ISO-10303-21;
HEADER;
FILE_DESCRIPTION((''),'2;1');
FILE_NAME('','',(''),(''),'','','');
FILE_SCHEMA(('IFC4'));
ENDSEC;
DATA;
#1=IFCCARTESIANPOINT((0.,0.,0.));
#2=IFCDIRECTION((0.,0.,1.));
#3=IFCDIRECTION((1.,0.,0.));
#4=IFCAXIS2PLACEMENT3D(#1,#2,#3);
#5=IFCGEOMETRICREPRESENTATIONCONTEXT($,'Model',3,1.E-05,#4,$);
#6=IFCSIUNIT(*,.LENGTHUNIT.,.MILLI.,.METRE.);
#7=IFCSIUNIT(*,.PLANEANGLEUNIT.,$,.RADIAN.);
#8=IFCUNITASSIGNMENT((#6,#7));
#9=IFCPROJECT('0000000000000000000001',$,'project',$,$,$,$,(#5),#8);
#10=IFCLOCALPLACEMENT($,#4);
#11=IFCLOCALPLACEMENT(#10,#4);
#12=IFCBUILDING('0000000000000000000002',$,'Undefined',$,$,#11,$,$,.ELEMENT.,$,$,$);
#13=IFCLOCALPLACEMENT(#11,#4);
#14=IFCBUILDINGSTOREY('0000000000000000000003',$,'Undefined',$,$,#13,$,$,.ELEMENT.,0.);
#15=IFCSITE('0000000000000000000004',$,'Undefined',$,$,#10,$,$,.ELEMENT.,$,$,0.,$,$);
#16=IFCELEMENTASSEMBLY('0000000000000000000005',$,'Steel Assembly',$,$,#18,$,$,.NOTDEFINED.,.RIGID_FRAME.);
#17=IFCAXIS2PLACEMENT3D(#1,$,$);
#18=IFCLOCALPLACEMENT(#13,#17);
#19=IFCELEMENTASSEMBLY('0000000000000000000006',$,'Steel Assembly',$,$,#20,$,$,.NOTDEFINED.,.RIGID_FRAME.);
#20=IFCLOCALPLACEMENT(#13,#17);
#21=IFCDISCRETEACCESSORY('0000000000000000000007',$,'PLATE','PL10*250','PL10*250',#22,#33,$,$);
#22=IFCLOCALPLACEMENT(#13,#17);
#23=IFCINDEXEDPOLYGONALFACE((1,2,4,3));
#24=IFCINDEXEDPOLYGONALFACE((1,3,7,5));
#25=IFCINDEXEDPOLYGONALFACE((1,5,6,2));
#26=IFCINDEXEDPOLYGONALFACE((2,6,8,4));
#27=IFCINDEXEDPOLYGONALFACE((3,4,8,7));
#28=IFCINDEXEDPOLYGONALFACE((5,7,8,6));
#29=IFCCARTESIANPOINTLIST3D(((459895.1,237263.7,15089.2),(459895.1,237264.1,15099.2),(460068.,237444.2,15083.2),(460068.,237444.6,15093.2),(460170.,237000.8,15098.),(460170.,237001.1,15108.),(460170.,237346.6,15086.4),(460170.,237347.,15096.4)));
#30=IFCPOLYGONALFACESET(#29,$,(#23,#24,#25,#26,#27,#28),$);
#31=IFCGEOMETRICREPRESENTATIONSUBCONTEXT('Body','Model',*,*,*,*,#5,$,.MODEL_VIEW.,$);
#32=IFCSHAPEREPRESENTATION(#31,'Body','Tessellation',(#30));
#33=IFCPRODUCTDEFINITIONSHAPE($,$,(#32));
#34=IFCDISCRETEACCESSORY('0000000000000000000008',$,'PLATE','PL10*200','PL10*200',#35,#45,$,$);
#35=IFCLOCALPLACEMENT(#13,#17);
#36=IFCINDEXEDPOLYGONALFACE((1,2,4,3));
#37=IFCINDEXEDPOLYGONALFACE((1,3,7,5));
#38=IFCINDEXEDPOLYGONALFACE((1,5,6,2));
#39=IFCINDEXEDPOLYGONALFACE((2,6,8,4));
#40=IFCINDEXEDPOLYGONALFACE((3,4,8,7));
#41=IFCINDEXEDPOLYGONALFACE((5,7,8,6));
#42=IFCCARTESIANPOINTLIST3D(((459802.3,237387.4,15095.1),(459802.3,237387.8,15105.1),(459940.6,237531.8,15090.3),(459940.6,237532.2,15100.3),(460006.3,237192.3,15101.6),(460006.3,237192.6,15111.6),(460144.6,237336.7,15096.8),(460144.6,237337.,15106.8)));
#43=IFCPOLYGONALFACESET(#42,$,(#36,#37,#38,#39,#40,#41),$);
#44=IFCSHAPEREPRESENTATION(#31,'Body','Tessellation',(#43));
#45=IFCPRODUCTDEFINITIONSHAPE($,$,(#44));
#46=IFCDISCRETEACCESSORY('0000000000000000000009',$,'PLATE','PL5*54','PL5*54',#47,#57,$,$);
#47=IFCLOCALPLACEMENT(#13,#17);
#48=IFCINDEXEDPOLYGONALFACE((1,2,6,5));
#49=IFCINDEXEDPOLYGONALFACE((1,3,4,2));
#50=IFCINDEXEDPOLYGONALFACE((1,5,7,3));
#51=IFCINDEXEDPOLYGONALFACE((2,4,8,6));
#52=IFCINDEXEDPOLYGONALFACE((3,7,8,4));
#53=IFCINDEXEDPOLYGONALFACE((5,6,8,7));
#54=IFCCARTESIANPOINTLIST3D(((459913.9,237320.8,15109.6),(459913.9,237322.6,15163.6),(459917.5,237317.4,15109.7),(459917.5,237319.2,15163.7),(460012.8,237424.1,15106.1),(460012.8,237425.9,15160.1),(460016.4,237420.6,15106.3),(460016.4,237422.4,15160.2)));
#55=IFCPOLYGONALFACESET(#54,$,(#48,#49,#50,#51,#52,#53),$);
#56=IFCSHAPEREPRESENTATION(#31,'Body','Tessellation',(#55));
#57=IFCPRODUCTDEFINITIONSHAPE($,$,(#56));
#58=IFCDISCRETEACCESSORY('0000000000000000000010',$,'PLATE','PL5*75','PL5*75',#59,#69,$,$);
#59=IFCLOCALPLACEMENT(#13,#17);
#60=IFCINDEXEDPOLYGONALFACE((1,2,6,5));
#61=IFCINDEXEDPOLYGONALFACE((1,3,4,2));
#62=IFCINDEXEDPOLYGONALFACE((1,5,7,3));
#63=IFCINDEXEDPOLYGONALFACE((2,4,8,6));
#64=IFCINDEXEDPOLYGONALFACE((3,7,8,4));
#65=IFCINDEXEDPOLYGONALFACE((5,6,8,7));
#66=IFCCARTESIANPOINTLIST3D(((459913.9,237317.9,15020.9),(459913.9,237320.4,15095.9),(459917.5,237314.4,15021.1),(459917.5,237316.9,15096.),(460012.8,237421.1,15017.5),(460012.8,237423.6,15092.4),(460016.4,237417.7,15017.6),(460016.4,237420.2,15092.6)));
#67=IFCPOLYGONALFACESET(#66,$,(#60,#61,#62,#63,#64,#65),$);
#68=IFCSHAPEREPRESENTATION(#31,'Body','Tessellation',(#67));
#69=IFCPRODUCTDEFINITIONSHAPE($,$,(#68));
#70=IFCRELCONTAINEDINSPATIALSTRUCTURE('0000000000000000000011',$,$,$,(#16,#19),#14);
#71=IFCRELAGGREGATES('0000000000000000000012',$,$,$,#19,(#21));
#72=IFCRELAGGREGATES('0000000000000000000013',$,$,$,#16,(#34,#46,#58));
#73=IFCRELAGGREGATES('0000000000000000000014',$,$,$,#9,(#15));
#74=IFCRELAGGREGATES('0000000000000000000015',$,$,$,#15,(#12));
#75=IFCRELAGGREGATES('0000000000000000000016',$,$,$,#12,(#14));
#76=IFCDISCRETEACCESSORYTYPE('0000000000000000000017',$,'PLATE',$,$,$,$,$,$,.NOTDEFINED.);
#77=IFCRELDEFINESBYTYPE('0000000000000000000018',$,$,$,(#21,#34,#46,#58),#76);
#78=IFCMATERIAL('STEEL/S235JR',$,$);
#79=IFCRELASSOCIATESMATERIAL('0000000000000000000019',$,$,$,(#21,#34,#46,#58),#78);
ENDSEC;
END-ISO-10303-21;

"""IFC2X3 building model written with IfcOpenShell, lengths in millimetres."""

from ifc_helpers import new_model, si_unit, frame, origin_with_axes, place, context, subcontext, project, spatial, polyline, outline, extrude, material, type_object, element, aggregate, save


model = new_model("IFC2X3")

# Units and contexts
model_context = context("Model", 3, precision=1e-05, world=origin_with_axes())
body_context = subcontext(model_context, "Body", "Model", "MODEL_VIEW")
ifc_project = project(units=[si_unit("LENGTHUNIT", "METRE", prefix="MILLI"), si_unit("PLANEANGLEUNIT", "RADIAN")], contexts=[model_context])

# Site, building, storey
site_placement = place(None, origin_with_axes())
site = spatial("IfcSite", under=ifc_project, at=site_placement, Name="Undefined", CompositionType="ELEMENT", RefElevation=0.0)
building_placement = place(site_placement, origin_with_axes())
building = spatial("IfcBuilding", under=site, at=building_placement, Name="Undefined", CompositionType="ELEMENT")
storey_placement = place(building_placement, origin_with_axes())
storey = spatial("IfcBuildingStorey", under=building, at=storey_placement, Name="Undefined", CompositionType="ELEMENT", Elevation=0.0)

# Element assembly
assembly_1_placement = place(storey_placement, origin_with_axes())
assembly_1 = element("IfcElementAssembly", 1, at=assembly_1_placement, inside=storey, Name="Steel Assembly", AssemblyPlace="NOTDEFINED", PredefinedType="RIGID_FRAME")

# Element assembly
ifc_material_1 = material(Name="STEEL/S235JR")
assembly_2_placement = place(storey_placement, origin_with_axes())
assembly_2 = element("IfcElementAssembly", 2, at=assembly_2_placement, inside=storey, Name="Steel Assembly", AssemblyPlace="NOTDEFINED", PredefinedType="RIGID_FRAME")
discrete_accessory_type_1 = type_object("IfcDiscreteAccessoryType", Name="PLATE")

# Discrete accessories
discrete_accessory_1_placement = place(assembly_2_placement, frame((460170.0, 237001.0, 15103.0), z_axis=(-0.000068, -0.033386, -0.999443), x_axis=(-0.722439, 0.691051, -0.023035)))
discrete_accessory_1 = element("IfcDiscreteAccessory", 3, at=discrete_accessory_1_placement, type_object=discrete_accessory_type_1, material=ifc_material_1, Name="PLATE", Description="PL10*250", ObjectType="PL10*250", context=body_context, shape_type="SweptSolid", body=[
    extrude(outline(polyline([(0.0, 0.0), (380.5, 0.0), (380.5, 250.0), (239.3, 250.0), (0.0, 0.0)])), frame((0.0, 0.0, -5.0), z_axis=(0.0, 0.0, 1.0), x_axis=(1.0, 0.0, 0.0)), (0.0, 0.0, 1.0), 10.0),
])
aggregate(assembly_2, [discrete_accessory_1])
discrete_accessory_2_placement = place(assembly_1_placement, frame((460075.5, 237264.7, 15104.2), z_axis=(-0.000068, -0.033386, -0.999443), x_axis=(-0.722439, 0.691051, -0.023035)))
discrete_accessory_2 = element("IfcDiscreteAccessory", 4, at=discrete_accessory_2_placement, type_object=discrete_accessory_type_1, material=ifc_material_1, Name="PLATE", Description="PL10*200", ObjectType="PL10*200", context=body_context, shape_type="SweptSolid", body=[
    extrude(outline(polyline([(0.0, -100.0), (0.0, 100.0), (282.4, 100.0), (282.4, -100.0), (0.0, -100.0)])), frame((0.0, 0.0, -5.0), z_axis=(0.0, 0.0, 1.0), x_axis=(1.0, 0.0, 0.0)), (0.0, 0.0, 1.0), 10.0),
])
discrete_accessory_3_placement = place(assembly_1_placement, frame((459915.7, 237320.0, 15136.6), z_axis=(-0.722439, 0.691051, -0.023035), x_axis=(0.691434, 0.722035, -0.024166)))
discrete_accessory_3 = element("IfcDiscreteAccessory", 5, at=discrete_accessory_3_placement, type_object=discrete_accessory_type_1, material=ifc_material_1, Name="PLATE", Description="PL5*54", ObjectType="PL5*54", context=body_context, shape_type="SweptSolid", body=[
    extrude(outline(polyline([(143.0, 27.0), (143.0, -27.0), (0.0, -27.0), (0.0, 27.0), (143.0, 27.0)])), frame((0.0, 0.0, -2.5), z_axis=(0.0, 0.0, 1.0), x_axis=(1.0, 0.0, 0.0)), (0.0, 0.0, 1.0), 5.0),
])
discrete_accessory_4_placement = place(assembly_1_placement, frame((459915.7, 237317.4, 15058.5), z_axis=(0.722439, -0.691051, 0.023035), x_axis=(0.691434, 0.722035, -0.024166)))
discrete_accessory_4 = element("IfcDiscreteAccessory", 6, at=discrete_accessory_4_placement, type_object=discrete_accessory_type_1, material=ifc_material_1, Name="PLATE", Description="PL5*75", ObjectType="PL5*75", context=body_context, shape_type="SweptSolid", body=[
    extrude(outline(polyline([(0.0, 37.5), (143.0, 37.5), (143.0, -37.5), (0.0, -37.5), (0.0, 37.5)])), frame((0.0, 0.0, -2.5), z_axis=(0.0, 0.0, 1.0), x_axis=(1.0, 0.0, 0.0)), (0.0, 0.0, 1.0), 5.0),
])
aggregate(assembly_1, [discrete_accessory_2, discrete_accessory_3, discrete_accessory_4])

save(model, "model.ifc")
